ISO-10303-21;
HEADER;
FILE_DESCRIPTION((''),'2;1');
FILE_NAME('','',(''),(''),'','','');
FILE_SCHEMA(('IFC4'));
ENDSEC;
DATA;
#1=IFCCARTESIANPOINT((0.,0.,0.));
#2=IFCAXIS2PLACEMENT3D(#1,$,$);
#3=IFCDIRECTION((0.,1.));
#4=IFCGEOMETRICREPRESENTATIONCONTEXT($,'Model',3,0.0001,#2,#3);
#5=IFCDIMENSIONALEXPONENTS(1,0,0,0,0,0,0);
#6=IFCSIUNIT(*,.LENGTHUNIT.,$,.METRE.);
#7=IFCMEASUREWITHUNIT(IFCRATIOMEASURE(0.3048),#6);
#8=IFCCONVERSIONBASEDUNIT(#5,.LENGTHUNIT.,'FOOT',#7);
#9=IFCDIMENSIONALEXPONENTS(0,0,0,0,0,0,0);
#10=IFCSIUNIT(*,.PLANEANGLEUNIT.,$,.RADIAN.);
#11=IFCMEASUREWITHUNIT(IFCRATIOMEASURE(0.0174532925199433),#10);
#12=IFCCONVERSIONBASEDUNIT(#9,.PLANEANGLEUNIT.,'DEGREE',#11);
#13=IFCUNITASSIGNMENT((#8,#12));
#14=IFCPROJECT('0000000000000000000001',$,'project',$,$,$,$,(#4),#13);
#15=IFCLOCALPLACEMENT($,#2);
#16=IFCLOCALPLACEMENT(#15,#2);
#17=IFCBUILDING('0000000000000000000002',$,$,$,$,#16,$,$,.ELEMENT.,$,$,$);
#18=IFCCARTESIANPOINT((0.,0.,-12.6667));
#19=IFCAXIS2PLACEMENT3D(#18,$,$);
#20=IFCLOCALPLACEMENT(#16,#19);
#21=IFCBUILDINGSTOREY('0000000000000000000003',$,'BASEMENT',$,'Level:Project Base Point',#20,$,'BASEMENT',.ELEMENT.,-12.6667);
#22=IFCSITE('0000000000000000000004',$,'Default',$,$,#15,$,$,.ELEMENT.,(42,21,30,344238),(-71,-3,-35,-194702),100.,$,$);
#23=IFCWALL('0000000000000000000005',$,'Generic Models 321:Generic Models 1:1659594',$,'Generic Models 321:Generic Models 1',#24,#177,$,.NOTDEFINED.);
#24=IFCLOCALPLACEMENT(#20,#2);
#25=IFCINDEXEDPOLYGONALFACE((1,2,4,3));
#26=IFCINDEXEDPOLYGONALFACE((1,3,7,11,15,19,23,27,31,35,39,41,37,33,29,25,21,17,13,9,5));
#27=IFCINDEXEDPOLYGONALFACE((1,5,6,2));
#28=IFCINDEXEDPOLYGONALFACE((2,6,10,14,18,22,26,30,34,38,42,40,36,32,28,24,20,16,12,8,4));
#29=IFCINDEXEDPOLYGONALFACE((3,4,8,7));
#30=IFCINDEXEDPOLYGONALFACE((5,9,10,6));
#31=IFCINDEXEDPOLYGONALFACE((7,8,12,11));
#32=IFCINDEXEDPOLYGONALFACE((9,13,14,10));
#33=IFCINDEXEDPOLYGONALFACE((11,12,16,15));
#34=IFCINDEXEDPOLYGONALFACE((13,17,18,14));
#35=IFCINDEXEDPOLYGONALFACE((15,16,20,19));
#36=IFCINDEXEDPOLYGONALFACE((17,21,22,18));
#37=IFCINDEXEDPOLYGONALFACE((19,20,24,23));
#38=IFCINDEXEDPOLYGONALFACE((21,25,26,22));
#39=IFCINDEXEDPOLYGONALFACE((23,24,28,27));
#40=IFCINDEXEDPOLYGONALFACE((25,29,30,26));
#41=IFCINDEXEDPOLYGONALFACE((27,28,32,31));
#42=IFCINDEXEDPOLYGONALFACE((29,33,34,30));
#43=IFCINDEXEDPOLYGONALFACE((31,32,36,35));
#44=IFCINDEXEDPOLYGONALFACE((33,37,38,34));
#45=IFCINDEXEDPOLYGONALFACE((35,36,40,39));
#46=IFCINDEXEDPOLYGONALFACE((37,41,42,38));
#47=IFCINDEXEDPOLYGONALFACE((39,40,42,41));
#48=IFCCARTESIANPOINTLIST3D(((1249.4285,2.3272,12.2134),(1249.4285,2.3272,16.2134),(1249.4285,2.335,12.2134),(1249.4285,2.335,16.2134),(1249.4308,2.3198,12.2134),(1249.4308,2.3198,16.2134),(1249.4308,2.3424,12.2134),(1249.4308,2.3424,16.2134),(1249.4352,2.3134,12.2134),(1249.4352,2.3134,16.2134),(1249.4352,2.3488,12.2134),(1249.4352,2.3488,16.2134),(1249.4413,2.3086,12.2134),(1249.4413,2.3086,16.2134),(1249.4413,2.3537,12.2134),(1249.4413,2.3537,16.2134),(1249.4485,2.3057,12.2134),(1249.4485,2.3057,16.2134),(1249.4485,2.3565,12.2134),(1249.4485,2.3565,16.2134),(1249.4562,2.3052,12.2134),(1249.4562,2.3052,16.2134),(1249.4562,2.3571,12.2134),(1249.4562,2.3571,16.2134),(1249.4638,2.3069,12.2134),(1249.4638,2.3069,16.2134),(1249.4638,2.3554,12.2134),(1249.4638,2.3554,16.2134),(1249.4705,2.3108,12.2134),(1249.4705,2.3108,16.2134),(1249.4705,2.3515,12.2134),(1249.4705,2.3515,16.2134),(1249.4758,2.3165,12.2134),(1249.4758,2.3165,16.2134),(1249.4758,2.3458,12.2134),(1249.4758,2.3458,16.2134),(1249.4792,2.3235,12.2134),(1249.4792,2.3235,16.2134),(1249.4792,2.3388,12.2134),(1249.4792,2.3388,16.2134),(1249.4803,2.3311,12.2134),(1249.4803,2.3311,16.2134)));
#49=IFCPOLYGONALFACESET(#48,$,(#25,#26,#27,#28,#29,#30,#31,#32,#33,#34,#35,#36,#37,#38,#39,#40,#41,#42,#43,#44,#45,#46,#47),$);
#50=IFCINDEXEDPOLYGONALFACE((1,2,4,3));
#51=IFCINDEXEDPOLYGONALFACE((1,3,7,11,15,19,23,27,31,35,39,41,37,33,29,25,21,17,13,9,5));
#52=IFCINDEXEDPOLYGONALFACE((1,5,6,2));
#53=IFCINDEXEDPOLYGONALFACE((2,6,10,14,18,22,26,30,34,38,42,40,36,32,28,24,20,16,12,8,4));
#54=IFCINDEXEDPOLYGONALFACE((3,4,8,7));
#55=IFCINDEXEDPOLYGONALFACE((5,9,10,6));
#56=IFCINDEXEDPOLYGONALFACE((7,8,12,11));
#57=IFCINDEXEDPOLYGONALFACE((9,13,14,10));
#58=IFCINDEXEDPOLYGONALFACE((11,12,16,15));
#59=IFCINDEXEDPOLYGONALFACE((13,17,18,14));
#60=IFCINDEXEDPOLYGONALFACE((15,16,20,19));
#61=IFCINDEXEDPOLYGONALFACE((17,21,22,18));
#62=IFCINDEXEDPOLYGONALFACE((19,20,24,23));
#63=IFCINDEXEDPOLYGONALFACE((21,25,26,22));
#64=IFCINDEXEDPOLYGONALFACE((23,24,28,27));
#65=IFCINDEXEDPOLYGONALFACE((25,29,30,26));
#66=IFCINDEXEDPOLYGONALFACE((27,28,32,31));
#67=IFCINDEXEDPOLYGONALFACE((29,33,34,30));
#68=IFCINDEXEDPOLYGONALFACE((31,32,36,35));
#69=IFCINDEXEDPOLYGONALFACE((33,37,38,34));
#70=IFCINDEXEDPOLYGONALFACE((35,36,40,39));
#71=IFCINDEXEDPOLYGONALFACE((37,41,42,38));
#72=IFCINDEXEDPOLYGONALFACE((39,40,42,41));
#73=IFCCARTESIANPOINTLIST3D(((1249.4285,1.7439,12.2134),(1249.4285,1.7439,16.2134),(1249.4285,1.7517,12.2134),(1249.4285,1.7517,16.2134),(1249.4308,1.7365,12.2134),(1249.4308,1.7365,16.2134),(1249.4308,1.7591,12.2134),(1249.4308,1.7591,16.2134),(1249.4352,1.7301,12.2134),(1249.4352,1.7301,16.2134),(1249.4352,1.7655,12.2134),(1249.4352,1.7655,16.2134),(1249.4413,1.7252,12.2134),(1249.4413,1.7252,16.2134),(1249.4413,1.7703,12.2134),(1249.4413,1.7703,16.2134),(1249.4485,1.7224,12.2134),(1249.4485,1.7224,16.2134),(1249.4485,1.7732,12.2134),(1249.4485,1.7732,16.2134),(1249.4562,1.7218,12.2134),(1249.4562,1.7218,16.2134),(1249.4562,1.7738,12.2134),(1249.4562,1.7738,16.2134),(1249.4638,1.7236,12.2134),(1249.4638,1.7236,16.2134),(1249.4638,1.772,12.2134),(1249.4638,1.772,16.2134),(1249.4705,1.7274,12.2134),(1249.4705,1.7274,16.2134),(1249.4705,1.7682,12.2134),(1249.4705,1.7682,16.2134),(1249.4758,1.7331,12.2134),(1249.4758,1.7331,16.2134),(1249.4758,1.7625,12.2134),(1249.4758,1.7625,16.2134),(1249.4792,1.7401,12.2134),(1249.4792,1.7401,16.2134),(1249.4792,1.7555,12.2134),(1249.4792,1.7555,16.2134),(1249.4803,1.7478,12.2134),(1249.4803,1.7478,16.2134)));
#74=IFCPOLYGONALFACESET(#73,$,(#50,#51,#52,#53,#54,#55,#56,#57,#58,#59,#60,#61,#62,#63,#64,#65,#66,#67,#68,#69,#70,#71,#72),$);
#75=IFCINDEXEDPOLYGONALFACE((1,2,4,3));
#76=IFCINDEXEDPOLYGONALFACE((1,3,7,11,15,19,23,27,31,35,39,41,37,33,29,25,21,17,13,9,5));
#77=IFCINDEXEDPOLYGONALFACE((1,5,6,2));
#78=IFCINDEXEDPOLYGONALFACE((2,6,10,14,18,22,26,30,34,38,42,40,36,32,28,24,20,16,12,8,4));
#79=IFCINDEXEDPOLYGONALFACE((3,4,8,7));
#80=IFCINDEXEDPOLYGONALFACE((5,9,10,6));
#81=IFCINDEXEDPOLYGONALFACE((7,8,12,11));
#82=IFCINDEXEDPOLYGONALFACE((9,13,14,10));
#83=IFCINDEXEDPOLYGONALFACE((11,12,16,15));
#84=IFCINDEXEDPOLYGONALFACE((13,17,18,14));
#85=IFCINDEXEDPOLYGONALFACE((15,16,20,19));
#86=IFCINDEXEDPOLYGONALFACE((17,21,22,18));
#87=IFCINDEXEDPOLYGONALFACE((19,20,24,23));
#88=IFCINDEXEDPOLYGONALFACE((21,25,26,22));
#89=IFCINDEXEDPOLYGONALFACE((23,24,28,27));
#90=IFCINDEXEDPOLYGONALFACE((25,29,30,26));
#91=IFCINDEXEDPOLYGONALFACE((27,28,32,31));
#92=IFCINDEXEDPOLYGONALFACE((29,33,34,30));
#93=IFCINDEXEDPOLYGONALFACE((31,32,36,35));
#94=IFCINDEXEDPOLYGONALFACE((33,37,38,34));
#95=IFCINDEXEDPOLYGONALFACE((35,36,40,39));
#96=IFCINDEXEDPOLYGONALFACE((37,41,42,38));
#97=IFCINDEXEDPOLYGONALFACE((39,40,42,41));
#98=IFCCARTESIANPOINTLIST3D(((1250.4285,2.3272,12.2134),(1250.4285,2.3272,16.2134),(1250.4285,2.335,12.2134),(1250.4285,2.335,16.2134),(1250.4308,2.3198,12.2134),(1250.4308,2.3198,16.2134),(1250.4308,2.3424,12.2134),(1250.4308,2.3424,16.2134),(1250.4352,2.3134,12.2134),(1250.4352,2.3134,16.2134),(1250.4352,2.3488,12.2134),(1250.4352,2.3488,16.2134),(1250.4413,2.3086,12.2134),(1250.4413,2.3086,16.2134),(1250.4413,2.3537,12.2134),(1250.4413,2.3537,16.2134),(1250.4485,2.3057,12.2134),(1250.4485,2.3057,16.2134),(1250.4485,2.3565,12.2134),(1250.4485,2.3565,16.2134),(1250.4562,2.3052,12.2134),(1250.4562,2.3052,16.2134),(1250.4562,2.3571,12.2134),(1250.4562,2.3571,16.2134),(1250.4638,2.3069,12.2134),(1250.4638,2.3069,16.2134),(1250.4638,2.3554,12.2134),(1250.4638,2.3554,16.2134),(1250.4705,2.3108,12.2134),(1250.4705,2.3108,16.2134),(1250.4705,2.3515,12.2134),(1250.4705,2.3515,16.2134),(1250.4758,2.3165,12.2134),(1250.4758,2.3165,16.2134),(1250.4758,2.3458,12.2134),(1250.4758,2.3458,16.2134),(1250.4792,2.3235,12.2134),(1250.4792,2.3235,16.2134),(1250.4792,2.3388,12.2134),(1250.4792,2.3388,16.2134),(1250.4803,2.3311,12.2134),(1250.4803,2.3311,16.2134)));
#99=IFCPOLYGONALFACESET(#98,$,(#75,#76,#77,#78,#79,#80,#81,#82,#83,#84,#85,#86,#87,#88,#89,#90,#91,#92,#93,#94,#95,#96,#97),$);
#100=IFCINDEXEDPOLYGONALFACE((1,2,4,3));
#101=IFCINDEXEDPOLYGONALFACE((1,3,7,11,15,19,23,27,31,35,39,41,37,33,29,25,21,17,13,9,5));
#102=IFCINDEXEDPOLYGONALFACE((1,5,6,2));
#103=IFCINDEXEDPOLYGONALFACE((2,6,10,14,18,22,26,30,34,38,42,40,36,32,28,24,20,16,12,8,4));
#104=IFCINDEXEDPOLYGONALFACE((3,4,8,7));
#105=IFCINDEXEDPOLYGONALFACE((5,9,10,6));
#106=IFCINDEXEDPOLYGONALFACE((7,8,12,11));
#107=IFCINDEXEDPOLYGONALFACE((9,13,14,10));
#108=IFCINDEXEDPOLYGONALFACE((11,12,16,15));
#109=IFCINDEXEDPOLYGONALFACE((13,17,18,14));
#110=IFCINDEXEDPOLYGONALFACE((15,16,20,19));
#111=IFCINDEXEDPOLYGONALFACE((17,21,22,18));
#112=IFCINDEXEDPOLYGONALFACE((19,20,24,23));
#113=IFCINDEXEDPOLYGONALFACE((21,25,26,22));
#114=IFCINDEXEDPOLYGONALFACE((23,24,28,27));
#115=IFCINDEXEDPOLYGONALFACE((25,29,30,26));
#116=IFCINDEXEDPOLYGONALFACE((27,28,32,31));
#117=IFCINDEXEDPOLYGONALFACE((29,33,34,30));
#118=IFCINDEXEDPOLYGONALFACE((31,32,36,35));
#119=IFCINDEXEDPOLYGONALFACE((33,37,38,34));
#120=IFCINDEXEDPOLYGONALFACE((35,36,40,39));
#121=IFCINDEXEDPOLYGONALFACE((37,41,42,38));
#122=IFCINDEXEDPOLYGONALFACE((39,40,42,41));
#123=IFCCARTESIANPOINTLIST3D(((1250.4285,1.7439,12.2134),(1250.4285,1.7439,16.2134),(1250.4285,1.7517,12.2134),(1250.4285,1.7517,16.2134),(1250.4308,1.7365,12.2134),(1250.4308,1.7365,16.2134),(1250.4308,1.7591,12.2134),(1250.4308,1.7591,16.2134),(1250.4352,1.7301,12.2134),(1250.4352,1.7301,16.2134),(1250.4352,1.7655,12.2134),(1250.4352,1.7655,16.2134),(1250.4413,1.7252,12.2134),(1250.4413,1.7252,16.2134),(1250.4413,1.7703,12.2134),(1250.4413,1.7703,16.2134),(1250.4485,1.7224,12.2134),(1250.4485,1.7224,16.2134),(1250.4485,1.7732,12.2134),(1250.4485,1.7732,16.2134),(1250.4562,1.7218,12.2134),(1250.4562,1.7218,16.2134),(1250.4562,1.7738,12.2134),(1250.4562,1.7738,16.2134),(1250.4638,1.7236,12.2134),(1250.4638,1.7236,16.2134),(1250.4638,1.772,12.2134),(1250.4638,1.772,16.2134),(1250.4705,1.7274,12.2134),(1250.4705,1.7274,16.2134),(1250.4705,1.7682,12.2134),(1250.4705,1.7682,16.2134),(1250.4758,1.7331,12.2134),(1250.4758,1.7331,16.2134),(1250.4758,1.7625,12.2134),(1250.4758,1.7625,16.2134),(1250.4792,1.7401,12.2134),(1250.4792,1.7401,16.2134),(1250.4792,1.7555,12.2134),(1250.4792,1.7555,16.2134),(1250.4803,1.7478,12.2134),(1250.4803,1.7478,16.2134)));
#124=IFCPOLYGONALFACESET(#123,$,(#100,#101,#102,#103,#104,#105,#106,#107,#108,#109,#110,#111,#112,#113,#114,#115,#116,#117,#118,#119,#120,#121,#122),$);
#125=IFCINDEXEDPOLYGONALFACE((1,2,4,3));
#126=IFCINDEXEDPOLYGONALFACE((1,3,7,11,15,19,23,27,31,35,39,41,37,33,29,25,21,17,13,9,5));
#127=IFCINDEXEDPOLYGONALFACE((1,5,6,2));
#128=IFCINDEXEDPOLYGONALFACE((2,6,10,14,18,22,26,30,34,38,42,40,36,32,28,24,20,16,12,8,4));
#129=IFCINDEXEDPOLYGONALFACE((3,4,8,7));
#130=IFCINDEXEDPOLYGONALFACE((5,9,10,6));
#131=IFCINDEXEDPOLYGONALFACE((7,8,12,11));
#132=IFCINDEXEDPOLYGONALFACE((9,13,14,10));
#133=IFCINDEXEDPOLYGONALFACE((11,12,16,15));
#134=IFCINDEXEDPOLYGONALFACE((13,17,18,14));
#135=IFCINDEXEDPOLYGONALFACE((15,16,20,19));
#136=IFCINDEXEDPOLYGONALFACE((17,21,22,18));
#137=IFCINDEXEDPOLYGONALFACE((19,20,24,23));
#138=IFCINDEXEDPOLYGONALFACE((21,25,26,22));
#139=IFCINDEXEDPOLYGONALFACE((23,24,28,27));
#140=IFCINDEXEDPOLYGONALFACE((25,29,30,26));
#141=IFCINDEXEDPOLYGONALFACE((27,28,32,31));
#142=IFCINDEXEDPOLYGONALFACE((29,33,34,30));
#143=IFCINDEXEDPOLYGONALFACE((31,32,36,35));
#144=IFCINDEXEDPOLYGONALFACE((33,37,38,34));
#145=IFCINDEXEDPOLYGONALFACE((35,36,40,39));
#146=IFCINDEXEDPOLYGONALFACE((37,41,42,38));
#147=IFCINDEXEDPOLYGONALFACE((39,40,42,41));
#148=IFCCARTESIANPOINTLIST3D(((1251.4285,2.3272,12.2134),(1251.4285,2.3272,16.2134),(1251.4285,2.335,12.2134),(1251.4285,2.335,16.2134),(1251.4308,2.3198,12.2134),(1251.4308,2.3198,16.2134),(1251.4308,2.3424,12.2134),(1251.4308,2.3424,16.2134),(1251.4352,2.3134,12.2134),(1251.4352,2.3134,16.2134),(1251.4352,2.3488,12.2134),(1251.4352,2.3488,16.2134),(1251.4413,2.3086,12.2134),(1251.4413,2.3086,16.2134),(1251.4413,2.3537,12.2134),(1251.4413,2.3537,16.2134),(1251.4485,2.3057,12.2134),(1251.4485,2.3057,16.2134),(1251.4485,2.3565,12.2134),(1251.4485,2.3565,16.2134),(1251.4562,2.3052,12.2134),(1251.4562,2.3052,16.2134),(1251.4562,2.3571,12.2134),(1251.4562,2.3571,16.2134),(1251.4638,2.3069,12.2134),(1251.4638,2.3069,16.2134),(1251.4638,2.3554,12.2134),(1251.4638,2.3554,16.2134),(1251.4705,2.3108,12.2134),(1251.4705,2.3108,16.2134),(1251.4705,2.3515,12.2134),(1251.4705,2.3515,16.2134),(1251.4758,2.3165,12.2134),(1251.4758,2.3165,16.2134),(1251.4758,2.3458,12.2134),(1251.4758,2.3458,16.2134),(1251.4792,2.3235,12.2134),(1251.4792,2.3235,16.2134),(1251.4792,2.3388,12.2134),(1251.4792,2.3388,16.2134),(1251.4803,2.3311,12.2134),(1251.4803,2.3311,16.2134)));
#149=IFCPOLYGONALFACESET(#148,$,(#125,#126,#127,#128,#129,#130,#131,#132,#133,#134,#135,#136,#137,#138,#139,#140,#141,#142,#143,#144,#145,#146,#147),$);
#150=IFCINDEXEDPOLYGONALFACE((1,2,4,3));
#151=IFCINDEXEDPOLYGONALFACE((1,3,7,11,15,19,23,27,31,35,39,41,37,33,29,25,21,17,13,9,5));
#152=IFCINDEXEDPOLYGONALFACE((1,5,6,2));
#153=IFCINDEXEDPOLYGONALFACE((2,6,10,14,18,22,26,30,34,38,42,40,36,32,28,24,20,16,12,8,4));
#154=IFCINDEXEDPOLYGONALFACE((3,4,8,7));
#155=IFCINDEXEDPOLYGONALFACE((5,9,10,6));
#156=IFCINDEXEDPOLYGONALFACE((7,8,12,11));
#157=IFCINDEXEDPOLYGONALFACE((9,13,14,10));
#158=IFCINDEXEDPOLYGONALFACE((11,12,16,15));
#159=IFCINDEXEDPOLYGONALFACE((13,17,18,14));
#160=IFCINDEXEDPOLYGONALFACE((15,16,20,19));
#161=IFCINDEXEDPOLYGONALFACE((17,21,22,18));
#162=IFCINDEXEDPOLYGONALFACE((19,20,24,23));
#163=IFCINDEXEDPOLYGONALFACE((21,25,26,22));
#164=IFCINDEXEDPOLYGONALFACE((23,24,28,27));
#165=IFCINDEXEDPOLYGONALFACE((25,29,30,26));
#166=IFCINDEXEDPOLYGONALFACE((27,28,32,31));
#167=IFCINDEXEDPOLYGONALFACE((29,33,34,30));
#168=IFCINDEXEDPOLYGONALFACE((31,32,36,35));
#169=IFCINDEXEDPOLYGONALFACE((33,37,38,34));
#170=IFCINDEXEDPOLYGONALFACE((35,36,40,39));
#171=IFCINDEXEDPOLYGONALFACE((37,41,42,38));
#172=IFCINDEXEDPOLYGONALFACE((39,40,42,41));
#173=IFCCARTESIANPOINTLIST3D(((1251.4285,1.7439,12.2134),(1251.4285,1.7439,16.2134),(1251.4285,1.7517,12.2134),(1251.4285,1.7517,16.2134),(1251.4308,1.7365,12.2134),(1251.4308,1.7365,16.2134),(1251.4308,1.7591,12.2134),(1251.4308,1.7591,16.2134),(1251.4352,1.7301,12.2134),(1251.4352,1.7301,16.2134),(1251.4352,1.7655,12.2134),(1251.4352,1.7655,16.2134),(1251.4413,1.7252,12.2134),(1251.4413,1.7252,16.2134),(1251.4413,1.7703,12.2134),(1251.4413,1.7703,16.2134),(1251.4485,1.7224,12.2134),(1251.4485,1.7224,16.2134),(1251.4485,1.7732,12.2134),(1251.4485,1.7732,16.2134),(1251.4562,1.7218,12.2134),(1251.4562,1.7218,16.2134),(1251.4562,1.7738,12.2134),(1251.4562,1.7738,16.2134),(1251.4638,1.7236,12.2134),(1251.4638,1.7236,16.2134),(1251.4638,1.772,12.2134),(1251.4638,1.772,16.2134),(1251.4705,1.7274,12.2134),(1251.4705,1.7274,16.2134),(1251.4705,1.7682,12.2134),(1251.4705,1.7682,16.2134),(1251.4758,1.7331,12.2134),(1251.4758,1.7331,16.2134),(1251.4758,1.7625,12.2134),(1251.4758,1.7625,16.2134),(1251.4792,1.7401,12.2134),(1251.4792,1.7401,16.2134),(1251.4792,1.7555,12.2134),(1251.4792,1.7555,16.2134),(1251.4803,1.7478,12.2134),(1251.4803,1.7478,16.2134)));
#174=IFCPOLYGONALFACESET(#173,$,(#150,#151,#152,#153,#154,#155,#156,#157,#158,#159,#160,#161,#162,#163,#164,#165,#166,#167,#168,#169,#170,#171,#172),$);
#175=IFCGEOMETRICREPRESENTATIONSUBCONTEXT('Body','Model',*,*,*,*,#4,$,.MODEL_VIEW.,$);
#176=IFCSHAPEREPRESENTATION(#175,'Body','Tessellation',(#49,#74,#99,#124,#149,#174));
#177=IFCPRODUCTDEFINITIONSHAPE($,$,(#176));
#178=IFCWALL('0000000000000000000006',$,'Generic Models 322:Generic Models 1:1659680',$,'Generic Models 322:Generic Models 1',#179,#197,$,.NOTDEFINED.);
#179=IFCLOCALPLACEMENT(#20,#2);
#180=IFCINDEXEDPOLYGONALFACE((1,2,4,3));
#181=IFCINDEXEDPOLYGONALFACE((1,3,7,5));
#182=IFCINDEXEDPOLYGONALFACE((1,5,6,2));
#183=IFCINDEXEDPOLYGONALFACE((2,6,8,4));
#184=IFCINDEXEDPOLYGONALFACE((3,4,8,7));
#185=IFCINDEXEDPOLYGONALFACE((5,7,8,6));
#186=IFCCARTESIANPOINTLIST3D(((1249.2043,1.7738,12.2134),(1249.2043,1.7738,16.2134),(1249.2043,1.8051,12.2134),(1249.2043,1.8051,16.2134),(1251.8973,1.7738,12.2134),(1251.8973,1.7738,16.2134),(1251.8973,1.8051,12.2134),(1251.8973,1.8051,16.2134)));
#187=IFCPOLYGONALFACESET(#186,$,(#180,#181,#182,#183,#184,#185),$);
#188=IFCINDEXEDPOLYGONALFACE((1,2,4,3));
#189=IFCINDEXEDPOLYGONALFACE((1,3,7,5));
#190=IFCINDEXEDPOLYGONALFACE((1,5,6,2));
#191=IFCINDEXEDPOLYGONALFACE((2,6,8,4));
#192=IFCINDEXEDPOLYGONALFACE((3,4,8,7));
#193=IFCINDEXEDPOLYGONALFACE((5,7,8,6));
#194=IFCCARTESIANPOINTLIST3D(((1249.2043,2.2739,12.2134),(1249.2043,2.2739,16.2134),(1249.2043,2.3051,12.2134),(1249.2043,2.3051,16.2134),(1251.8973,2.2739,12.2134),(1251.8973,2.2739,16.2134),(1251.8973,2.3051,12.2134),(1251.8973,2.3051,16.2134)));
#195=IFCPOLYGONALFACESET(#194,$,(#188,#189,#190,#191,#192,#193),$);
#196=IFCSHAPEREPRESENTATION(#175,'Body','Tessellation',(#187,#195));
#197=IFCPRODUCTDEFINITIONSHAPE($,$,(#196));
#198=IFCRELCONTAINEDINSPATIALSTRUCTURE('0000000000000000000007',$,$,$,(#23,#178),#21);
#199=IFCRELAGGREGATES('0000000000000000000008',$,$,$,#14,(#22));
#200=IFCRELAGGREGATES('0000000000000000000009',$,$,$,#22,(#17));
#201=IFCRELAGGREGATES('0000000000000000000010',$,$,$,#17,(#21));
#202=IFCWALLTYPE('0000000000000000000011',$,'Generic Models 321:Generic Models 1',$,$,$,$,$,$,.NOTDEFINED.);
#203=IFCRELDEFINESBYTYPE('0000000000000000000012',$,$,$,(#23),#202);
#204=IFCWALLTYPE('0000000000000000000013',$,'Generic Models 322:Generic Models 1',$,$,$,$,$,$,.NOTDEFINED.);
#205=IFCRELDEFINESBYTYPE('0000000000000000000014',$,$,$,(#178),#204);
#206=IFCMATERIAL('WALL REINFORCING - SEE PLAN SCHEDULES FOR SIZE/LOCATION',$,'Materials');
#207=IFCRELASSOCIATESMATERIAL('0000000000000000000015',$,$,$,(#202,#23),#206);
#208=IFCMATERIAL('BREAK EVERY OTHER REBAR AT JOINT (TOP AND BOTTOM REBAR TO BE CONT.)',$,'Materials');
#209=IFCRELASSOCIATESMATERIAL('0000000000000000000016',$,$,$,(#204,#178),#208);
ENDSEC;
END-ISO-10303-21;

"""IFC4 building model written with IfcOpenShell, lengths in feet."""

from ifc_helpers import new_model, entity, si_unit, converted_unit, direction, frame, origin, origin_2d_with_axis, place, context, subcontext, project, spatial, rectangle, circle, extrude, material, type_object, element, save


model = new_model("IFC4")

# Units and contexts
model_context = context("Model", 3, precision=0.0001, world=origin(), true_north=direction((0.0, 1.0)))
body_context = subcontext(model_context, "Body", "Model", "MODEL_VIEW")
ifc_project = project(units=[converted_unit("LENGTHUNIT", "FOOT", entity("IfcRatioMeasure", 0.3048), si_unit("LENGTHUNIT", "METRE"), dimensions=[1, 0, 0, 0, 0, 0, 0]), converted_unit("PLANEANGLEUNIT", "DEGREE", entity("IfcRatioMeasure", 0.0174532925199433), si_unit("PLANEANGLEUNIT", "RADIAN"), dimensions=[0, 0, 0, 0, 0, 0, 0])], contexts=[model_context])

# Site, building, storey
site_placement = place(None, origin())
site = spatial("IfcSite", under=ifc_project, at=site_placement, Name="Default", CompositionType="ELEMENT", RefLatitude=(42, 21, 30, 344238), RefLongitude=(-71, -3, -35, -194702), RefElevation=100.0)
building_placement = place(site_placement, origin())
building = spatial("IfcBuilding", under=site, at=building_placement, CompositionType="ELEMENT")
storey_placement = place(building_placement, frame((0.0, 0.0, -12.6667)))
storey = spatial("IfcBuildingStorey", under=building, at=storey_placement, Name="BASEMENT", ObjectType="Level:Project Base Point", LongName="BASEMENT", CompositionType="ELEMENT", Elevation=-12.6667)

# Walls
ifc_material_1 = material(Name="WALL REINFORCING - SEE PLAN SCHEDULES FOR SIZE/LOCATION", Category="Materials")
wall_type_1 = type_object("IfcWallType", Name="Generic Models 321:Generic Models 1", PredefinedType="NOTDEFINED", material=ifc_material_1)
wall_1_placement = place(storey_placement, frame((1249.4282, 1.7218, 12.2134)))
element("IfcWall", 1, at=wall_1_placement, inside=storey, type_object=wall_type_1, material=ifc_material_1, Name="Generic Models 321:Generic Models 1:1659594", ObjectType="Generic Models 321:Generic Models 1", PredefinedType="NOTDEFINED", context=body_context, shape_type="SweptSolid", body=[
    extrude(circle(Radius=0.026, at=origin_2d_with_axis()), frame((0.026, 0.6094, 0.0)), (0.0, 0.0, 1.0), 4.0),
    extrude(circle(Radius=0.026, at=origin_2d_with_axis()), frame((0.026, 0.026, 0.0)), (0.0, 0.0, 1.0), 4.0),
    extrude(circle(Radius=0.026, at=origin_2d_with_axis()), frame((1.026, 0.6094, 0.0)), (0.0, 0.0, 1.0), 4.0),
    extrude(circle(Radius=0.026, at=origin_2d_with_axis()), frame((1.026, 0.026, 0.0)), (0.0, 0.0, 1.0), 4.0),
    extrude(circle(Radius=0.026, at=origin_2d_with_axis()), frame((2.026, 0.6094, 0.0)), (0.0, 0.0, 1.0), 4.0),
    extrude(circle(Radius=0.026, at=origin_2d_with_axis()), frame((2.026, 0.026, 0.0)), (0.0, 0.0, 1.0), 4.0),
])
ifc_material_2 = material(Name="BREAK EVERY OTHER REBAR AT JOINT (TOP AND BOTTOM REBAR TO BE CONT.)", Category="Materials")
wall_type_2 = type_object("IfcWallType", Name="Generic Models 322:Generic Models 1", PredefinedType="NOTDEFINED", material=ifc_material_2)
wall_2_placement = place(storey_placement, frame((1249.2043, 1.7738, 12.2134)))
element("IfcWall", 2, at=wall_2_placement, inside=storey, type_object=wall_type_2, material=ifc_material_2, Name="Generic Models 322:Generic Models 1:1659680", ObjectType="Generic Models 322:Generic Models 1", PredefinedType="NOTDEFINED", context=body_context, shape_type="SweptSolid", body=[
    extrude(rectangle(XDim=0.0312, YDim=2.693, at=origin_2d_with_axis()), frame((1.3465, 0.0156, 0.0), z_axis=(0.0, 0.0, 1.0), x_axis=(0.0, 1.0, 0.0)), (0.0, 0.0, 1.0), 4.0),
    extrude(rectangle(XDim=0.0312, YDim=2.693, at=origin_2d_with_axis()), frame((1.3465, 0.5157, 0.0), z_axis=(0.0, 0.0, 1.0), x_axis=(0.0, 1.0, 0.0)), (0.0, 0.0, 1.0), 4.0),
])

save(model, "model.ifc")
